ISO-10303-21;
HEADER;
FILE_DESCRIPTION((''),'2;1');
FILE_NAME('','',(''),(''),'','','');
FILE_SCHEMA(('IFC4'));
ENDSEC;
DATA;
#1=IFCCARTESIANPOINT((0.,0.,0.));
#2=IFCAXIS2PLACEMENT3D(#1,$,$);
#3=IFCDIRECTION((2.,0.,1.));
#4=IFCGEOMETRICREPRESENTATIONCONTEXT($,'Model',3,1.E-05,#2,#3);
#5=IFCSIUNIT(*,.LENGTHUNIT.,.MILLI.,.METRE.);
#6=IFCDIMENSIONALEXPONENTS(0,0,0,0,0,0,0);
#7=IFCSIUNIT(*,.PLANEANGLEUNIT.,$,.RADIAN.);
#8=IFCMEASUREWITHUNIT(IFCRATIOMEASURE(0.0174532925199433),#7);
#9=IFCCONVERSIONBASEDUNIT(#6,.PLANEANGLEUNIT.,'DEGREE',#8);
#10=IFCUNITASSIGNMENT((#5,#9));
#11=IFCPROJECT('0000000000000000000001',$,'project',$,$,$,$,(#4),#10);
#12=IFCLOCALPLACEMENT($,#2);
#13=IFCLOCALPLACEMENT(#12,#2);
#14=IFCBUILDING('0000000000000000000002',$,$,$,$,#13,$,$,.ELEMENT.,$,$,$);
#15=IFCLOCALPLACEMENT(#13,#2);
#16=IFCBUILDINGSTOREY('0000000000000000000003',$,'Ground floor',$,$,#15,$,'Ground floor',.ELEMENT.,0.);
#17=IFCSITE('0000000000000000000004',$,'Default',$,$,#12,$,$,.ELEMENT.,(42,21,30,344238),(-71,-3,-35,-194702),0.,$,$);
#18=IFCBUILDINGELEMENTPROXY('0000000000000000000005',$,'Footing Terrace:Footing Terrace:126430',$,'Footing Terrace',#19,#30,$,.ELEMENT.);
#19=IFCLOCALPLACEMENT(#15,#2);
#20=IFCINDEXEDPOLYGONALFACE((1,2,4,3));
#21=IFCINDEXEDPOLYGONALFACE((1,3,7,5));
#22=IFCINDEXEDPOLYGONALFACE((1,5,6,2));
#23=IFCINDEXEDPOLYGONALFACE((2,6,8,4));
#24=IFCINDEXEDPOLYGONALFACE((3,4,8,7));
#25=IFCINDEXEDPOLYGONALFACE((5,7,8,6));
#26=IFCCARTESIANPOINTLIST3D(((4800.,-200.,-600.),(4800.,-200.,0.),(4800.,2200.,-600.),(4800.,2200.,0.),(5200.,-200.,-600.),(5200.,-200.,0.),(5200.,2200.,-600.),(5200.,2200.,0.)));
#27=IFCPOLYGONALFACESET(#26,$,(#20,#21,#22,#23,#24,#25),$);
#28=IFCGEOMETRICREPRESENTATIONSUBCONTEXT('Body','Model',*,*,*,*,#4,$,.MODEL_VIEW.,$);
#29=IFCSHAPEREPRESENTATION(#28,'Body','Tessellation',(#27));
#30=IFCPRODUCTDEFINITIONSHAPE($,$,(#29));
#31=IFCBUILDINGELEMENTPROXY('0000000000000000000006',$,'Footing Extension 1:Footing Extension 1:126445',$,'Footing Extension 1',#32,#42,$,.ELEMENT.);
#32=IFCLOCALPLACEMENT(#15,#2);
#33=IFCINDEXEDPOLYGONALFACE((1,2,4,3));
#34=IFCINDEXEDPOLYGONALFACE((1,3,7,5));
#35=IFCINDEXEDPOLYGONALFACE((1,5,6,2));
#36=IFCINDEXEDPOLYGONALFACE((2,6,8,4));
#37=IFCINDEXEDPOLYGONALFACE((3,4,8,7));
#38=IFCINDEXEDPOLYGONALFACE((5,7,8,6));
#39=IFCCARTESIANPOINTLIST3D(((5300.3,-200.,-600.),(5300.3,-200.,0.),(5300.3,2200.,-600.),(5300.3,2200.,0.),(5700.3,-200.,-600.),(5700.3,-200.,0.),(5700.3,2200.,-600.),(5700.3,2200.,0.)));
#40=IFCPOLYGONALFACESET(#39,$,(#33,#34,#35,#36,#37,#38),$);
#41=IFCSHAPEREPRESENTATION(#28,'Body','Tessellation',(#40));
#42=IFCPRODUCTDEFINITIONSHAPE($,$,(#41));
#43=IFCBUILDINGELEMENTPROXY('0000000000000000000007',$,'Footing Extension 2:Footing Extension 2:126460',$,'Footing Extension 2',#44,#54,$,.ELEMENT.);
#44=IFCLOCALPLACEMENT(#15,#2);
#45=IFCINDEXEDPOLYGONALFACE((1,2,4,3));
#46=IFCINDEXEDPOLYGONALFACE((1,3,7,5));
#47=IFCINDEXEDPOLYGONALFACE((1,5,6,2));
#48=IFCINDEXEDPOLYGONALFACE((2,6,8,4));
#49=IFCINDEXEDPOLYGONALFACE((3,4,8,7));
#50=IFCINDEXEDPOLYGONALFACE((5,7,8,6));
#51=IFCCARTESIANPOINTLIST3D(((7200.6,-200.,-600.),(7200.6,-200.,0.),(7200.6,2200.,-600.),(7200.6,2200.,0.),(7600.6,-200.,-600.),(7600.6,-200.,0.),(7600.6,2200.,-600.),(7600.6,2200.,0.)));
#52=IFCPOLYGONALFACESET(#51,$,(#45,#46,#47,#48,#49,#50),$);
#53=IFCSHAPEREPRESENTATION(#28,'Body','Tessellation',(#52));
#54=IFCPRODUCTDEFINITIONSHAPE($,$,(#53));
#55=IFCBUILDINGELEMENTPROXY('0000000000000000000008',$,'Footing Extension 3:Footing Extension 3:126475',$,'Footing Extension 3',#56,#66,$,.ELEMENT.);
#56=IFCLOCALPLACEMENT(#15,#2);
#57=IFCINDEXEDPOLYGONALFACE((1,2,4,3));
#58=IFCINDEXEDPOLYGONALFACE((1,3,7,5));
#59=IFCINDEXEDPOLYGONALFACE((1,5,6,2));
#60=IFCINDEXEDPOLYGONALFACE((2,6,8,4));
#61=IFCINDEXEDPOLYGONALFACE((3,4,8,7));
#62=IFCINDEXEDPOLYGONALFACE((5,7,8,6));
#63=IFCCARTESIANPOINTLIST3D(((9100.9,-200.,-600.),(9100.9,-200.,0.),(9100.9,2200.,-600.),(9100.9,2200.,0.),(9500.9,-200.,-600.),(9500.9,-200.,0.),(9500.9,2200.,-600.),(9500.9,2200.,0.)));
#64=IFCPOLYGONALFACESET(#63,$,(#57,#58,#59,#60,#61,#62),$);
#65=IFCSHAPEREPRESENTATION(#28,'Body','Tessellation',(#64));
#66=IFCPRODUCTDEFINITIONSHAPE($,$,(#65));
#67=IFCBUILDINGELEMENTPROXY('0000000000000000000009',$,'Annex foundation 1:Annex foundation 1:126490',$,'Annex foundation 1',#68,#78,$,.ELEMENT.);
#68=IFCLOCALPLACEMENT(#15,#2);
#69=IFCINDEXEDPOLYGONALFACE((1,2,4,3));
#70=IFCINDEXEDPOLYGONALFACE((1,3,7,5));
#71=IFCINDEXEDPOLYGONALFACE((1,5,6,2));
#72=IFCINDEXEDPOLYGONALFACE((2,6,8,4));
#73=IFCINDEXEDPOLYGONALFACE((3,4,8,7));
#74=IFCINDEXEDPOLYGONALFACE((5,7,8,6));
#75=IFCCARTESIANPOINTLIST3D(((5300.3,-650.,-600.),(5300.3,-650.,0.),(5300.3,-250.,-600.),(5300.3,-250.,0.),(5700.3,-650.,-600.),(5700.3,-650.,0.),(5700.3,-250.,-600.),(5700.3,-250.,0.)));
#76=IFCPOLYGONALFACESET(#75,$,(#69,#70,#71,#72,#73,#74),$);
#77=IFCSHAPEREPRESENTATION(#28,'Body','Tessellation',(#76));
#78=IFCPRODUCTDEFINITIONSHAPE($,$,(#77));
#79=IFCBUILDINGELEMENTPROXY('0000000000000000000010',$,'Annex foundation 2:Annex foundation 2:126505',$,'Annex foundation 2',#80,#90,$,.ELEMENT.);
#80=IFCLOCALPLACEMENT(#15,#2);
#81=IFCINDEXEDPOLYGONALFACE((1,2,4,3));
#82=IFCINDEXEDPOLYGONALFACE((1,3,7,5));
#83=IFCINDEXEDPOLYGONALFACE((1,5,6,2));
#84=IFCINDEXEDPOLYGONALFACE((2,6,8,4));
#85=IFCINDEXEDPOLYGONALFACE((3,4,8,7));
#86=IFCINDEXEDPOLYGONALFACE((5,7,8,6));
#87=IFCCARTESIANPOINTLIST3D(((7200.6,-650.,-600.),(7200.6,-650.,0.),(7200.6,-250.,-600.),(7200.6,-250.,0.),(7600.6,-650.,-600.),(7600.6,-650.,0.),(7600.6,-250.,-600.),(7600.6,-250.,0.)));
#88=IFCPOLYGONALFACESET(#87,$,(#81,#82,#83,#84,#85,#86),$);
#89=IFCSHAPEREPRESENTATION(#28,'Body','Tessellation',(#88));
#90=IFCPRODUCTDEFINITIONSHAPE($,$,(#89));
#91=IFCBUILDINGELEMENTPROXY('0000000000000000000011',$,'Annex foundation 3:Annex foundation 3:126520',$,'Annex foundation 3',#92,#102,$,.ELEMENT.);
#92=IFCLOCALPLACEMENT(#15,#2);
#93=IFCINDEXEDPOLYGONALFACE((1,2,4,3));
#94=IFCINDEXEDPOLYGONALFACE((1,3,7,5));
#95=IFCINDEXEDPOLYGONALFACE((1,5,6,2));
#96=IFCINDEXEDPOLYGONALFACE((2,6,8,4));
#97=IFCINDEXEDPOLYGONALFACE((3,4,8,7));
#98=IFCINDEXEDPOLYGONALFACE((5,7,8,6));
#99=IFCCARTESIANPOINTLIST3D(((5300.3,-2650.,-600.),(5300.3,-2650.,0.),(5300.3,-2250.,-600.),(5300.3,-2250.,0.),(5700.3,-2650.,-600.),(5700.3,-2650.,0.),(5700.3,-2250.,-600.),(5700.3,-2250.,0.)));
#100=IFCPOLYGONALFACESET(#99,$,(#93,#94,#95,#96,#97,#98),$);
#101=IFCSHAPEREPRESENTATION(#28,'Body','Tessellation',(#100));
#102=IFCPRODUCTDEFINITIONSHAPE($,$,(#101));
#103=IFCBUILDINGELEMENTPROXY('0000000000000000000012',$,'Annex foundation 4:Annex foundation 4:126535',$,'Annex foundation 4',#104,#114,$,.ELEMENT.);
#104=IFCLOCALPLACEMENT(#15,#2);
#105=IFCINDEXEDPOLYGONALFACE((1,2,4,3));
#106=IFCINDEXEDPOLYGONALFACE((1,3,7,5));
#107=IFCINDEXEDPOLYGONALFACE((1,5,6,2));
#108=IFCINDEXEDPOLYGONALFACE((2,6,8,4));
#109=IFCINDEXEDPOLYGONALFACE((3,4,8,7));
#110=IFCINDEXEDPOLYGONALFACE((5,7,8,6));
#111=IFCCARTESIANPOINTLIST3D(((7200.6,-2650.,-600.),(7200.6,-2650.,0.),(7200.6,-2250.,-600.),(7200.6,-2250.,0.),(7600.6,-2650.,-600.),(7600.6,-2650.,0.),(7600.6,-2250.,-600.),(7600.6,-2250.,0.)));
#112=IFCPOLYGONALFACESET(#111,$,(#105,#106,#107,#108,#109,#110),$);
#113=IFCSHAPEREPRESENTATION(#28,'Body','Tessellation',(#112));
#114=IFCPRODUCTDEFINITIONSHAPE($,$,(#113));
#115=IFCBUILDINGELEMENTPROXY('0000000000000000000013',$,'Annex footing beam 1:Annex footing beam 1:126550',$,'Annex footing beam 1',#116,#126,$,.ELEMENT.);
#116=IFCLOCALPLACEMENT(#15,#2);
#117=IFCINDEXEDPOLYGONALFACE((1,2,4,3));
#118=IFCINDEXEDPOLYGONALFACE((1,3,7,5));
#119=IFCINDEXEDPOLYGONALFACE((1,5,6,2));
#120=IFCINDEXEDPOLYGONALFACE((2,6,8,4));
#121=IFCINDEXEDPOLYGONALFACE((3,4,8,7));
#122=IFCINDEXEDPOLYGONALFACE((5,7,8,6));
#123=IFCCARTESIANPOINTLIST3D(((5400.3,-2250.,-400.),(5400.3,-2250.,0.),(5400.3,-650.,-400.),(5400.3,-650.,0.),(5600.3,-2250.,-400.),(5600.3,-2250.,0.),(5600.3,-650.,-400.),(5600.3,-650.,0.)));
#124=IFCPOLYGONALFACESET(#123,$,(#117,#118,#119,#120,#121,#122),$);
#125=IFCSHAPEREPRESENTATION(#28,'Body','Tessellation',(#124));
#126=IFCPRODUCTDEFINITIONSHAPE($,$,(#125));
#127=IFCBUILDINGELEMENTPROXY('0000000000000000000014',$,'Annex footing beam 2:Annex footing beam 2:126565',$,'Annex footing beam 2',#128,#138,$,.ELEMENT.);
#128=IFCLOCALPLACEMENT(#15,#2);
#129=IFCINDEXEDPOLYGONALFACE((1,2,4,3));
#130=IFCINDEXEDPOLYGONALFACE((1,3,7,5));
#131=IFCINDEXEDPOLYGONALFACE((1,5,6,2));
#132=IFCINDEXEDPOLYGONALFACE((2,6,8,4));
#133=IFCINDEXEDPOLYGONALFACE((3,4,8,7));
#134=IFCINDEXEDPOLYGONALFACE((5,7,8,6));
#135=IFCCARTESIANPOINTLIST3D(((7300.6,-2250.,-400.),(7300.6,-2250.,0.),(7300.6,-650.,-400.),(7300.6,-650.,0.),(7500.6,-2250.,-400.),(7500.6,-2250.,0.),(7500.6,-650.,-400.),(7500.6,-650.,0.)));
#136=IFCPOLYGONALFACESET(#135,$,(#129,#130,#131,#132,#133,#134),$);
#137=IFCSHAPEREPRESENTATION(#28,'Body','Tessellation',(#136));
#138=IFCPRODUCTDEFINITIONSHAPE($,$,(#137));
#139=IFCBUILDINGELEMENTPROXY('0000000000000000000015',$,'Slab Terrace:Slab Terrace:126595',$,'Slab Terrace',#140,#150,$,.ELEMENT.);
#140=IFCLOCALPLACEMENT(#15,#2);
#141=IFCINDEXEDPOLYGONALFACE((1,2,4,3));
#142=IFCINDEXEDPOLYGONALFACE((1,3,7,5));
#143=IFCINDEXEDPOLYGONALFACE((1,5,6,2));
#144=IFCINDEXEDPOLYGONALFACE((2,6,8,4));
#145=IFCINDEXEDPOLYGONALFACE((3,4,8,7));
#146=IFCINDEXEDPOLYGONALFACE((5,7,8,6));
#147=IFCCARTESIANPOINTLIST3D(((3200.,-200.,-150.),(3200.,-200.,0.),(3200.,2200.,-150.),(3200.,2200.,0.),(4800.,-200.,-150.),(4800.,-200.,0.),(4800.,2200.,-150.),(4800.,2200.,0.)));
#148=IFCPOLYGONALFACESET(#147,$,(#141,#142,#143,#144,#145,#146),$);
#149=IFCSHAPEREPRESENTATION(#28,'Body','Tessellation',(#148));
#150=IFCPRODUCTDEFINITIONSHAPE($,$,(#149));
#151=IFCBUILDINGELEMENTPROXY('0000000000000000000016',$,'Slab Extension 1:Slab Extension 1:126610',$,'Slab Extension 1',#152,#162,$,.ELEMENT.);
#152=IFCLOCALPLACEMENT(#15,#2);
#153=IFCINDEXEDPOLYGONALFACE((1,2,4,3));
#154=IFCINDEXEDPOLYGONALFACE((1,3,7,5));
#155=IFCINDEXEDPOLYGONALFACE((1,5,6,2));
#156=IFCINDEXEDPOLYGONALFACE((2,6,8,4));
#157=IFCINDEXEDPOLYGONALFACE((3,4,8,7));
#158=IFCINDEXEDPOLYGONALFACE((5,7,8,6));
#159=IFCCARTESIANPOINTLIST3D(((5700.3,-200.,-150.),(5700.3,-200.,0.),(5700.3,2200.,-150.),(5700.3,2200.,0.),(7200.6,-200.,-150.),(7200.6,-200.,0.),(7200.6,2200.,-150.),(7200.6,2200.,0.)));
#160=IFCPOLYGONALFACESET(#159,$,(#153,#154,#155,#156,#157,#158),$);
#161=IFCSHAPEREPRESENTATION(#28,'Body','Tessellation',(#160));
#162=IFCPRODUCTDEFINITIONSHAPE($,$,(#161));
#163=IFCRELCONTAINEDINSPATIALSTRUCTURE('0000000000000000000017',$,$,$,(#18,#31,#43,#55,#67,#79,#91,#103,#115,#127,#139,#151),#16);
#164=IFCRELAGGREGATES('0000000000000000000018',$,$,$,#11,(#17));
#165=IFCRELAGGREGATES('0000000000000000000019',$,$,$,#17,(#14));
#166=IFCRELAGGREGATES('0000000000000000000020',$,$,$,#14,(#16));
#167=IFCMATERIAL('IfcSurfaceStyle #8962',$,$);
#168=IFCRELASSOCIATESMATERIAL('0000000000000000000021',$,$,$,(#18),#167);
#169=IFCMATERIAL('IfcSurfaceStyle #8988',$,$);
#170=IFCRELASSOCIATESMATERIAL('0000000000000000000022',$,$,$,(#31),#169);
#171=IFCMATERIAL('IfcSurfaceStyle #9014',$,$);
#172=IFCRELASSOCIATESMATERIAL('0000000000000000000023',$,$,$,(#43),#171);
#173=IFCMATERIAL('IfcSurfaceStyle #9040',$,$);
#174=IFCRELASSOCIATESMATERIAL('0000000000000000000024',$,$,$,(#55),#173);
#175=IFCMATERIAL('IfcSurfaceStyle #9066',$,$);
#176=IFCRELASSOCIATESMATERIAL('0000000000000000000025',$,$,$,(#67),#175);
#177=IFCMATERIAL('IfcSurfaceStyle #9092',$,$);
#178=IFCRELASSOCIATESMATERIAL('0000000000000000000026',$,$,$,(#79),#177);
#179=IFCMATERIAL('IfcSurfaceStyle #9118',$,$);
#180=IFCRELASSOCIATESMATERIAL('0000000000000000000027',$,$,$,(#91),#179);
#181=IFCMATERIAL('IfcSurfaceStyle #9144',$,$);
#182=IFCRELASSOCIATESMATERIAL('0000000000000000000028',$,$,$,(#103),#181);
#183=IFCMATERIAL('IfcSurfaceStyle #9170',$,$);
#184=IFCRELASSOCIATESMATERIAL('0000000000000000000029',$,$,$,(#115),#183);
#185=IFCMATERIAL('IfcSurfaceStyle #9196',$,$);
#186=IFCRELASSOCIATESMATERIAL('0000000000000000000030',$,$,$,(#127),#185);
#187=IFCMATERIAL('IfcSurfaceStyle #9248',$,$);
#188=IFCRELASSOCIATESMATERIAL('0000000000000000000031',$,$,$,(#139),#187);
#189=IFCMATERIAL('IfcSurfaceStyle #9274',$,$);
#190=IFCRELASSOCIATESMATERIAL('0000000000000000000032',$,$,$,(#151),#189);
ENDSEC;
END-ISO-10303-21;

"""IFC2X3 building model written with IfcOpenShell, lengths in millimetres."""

from ifc_helpers import new_model, entity, si_unit, converted_unit, direction, frame, frame_2d, origin, origin_2d_with_axis, place, context, subcontext, project, spatial, rectangle, extrude, source, transform, mapped, material, element, save


model = new_model("IFC2X3")

# Units and contexts
model_context = context("Model", 3, precision=1e-05, world=origin(), true_north=direction((2.0, 0.0, 1.0)))
body_context = subcontext(model_context, "Body", "Model", "MODEL_VIEW")
ifc_project = project(units=[si_unit("LENGTHUNIT", "METRE", prefix="MILLI"), converted_unit("PLANEANGLEUNIT", "DEGREE", entity("IfcRatioMeasure", 0.0174532925199433), si_unit("PLANEANGLEUNIT", "RADIAN"), dimensions=[0, 0, 0, 0, 0, 0, 0])], contexts=[model_context])

# Site, building, storey
site_placement = place(None, origin())
site = spatial("IfcSite", under=ifc_project, at=site_placement, Name="Default", CompositionType="ELEMENT", RefLatitude=(42, 21, 30, 344238), RefLongitude=(-71, -3, -35, -194702), RefElevation=0.0)
building_placement = place(site_placement, origin())
building = spatial("IfcBuilding", under=site, at=building_placement, CompositionType="ELEMENT")
storey_placement = place(building_placement, origin())
storey = spatial("IfcBuildingStorey", under=building, at=storey_placement, Name="Ground floor", LongName="Ground floor", CompositionType="ELEMENT", Elevation=0.0)

# Building element proxies
ifc_material_1 = material(Name="IfcSurfaceStyle #8962")
shared_shape_1 = source(origin(), body_context, "Body", "SweptSolid", [
    extrude(rectangle(XDim=2400.0, YDim=400.0, at=origin_2d_with_axis()), frame((200.0, 1200.0, 0.0), z_axis=(0.0, 0.0, 1.0), x_axis=(0.0, -1.0, 0.0)), (0.0, 0.0, 1.0), 600.0),
])
proxy_1_placement = place(building_placement, frame((4800.0, -200.0, -600.0)))
element("IfcBuildingElementProxy", 1, at=proxy_1_placement, inside=storey, material=ifc_material_1, Name="Footing Terrace:Footing Terrace:126430", ObjectType="Footing Terrace", CompositionType="ELEMENT", context=body_context, shape_type="MappedRepresentation", body=[
    mapped(shared_shape_1, transform((0.0, 0.0, 0.0), scale=1.0)),
])
ifc_material_2 = material(Name="IfcSurfaceStyle #8988")
shared_shape_2 = source(origin(), body_context, "Body", "SweptSolid", [
    extrude(rectangle(XDim=2400.0, YDim=400.0, at=origin_2d_with_axis()), frame((200.0, 1200.0, 0.0), z_axis=(0.0, 0.0, 1.0), x_axis=(0.0, -1.0, 0.0)), (0.0, 0.0, 1.0), 600.0),
])
proxy_2_placement = place(building_placement, frame((5300.3, -200.0, -600.0)))
element("IfcBuildingElementProxy", 2, at=proxy_2_placement, inside=storey, material=ifc_material_2, Name="Footing Extension 1:Footing Extension 1:126445", ObjectType="Footing Extension 1", CompositionType="ELEMENT", context=body_context, shape_type="MappedRepresentation", body=[
    mapped(shared_shape_2, transform((0.0, 0.0, 0.0), scale=1.0)),
])
ifc_material_3 = material(Name="IfcSurfaceStyle #9014")
shared_shape_3 = source(origin(), body_context, "Body", "SweptSolid", [
    extrude(rectangle(XDim=2400.0, YDim=400.0, at=origin_2d_with_axis()), frame((200.0, 1200.0, 0.0), z_axis=(0.0, 0.0, 1.0), x_axis=(0.0, -1.0, 0.0)), (0.0, 0.0, 1.0), 600.0),
])
proxy_3_placement = place(building_placement, frame((7200.6, -200.0, -600.0)))
element("IfcBuildingElementProxy", 3, at=proxy_3_placement, inside=storey, material=ifc_material_3, Name="Footing Extension 2:Footing Extension 2:126460", ObjectType="Footing Extension 2", CompositionType="ELEMENT", context=body_context, shape_type="MappedRepresentation", body=[
    mapped(shared_shape_3, transform((0.0, 0.0, 0.0), scale=1.0)),
])
ifc_material_4 = material(Name="IfcSurfaceStyle #9040")
shared_shape_4 = source(origin(), body_context, "Body", "SweptSolid", [
    extrude(rectangle(XDim=2400.0, YDim=400.0, at=origin_2d_with_axis()), frame((200.0, 1200.0, 0.0), z_axis=(0.0, 0.0, 1.0), x_axis=(0.0, -1.0, 0.0)), (0.0, 0.0, 1.0), 600.0),
])
proxy_4_placement = place(building_placement, frame((9100.9, -200.0, -600.0)))
element("IfcBuildingElementProxy", 4, at=proxy_4_placement, inside=storey, material=ifc_material_4, Name="Footing Extension 3:Footing Extension 3:126475", ObjectType="Footing Extension 3", CompositionType="ELEMENT", context=body_context, shape_type="MappedRepresentation", body=[
    mapped(shared_shape_4, transform((0.0, 0.0, 0.0), scale=1.0)),
])
ifc_material_5 = material(Name="IfcSurfaceStyle #9066")
shared_shape_5 = source(origin(), body_context, "Body", "SweptSolid", [
    extrude(rectangle(XDim=400.0, YDim=400.0, at=origin_2d_with_axis()), frame((200.0, 200.0, 0.0), z_axis=(0.0, 0.0, 1.0), x_axis=(0.0, 1.0, 0.0)), (0.0, 0.0, 1.0), 600.0),
])
proxy_5_placement = place(building_placement, frame((5300.3, -650.0, -600.0)))
element("IfcBuildingElementProxy", 5, at=proxy_5_placement, inside=storey, material=ifc_material_5, Name="Annex foundation 1:Annex foundation 1:126490", ObjectType="Annex foundation 1", CompositionType="ELEMENT", context=body_context, shape_type="MappedRepresentation", body=[
    mapped(shared_shape_5, transform((0.0, 0.0, 0.0), scale=1.0)),
])
ifc_material_6 = material(Name="IfcSurfaceStyle #9092")
shared_shape_6 = source(origin(), body_context, "Body", "SweptSolid", [
    extrude(rectangle(XDim=400.0, YDim=400.0, at=origin_2d_with_axis()), frame((200.0, 200.0, 0.0), z_axis=(0.0, 0.0, 1.0), x_axis=(0.0, 1.0, 0.0)), (0.0, 0.0, 1.0), 600.0),
])
proxy_6_placement = place(building_placement, frame((7200.6, -650.0, -600.0)))
element("IfcBuildingElementProxy", 6, at=proxy_6_placement, inside=storey, material=ifc_material_6, Name="Annex foundation 2:Annex foundation 2:126505", ObjectType="Annex foundation 2", CompositionType="ELEMENT", context=body_context, shape_type="MappedRepresentation", body=[
    mapped(shared_shape_6, transform((0.0, 0.0, 0.0), scale=1.0)),
])
ifc_material_7 = material(Name="IfcSurfaceStyle #9118")
shared_shape_7 = source(origin(), body_context, "Body", "SweptSolid", [
    extrude(rectangle(XDim=400.0, YDim=400.0, at=origin_2d_with_axis()), frame((200.0, 200.0, 0.0), z_axis=(0.0, 0.0, 1.0), x_axis=(0.0, 1.0, 0.0)), (0.0, 0.0, 1.0), 600.0),
])
proxy_7_placement = place(building_placement, frame((5300.3, -2650.0, -600.0)))
element("IfcBuildingElementProxy", 7, at=proxy_7_placement, inside=storey, material=ifc_material_7, Name="Annex foundation 3:Annex foundation 3:126520", ObjectType="Annex foundation 3", CompositionType="ELEMENT", context=body_context, shape_type="MappedRepresentation", body=[
    mapped(shared_shape_7, transform((0.0, 0.0, 0.0), scale=1.0)),
])
ifc_material_8 = material(Name="IfcSurfaceStyle #9144")
shared_shape_8 = source(origin(), body_context, "Body", "SweptSolid", [
    extrude(rectangle(XDim=400.0, YDim=400.0, at=origin_2d_with_axis()), frame((200.0, 200.0, 0.0), z_axis=(0.0, 0.0, 1.0), x_axis=(0.0, 1.0, 0.0)), (0.0, 0.0, 1.0), 600.0),
])
proxy_8_placement = place(building_placement, frame((7200.6, -2650.0, -600.0)))
element("IfcBuildingElementProxy", 8, at=proxy_8_placement, inside=storey, material=ifc_material_8, Name="Annex foundation 4:Annex foundation 4:126535", ObjectType="Annex foundation 4", CompositionType="ELEMENT", context=body_context, shape_type="MappedRepresentation", body=[
    mapped(shared_shape_8, transform((0.0, 0.0, 0.0), scale=1.0)),
])
ifc_material_9 = material(Name="IfcSurfaceStyle #9170")
shared_shape_9 = source(origin(), body_context, "Body", "SweptSolid", [
    extrude(rectangle(XDim=1600.0, YDim=200.0, at=origin_2d_with_axis()), frame((100.0, 800.0, 0.0), z_axis=(0.0, 0.0, 1.0), x_axis=(0.0, -1.0, 0.0)), (0.0, 0.0, 1.0), 400.0),
])
proxy_9_placement = place(building_placement, frame((5400.3, -2250.0, -400.0)))
element("IfcBuildingElementProxy", 9, at=proxy_9_placement, inside=storey, material=ifc_material_9, Name="Annex footing beam 1:Annex footing beam 1:126550", ObjectType="Annex footing beam 1", CompositionType="ELEMENT", context=body_context, shape_type="MappedRepresentation", body=[
    mapped(shared_shape_9, transform((0.0, 0.0, 0.0), scale=1.0)),
])
ifc_material_10 = material(Name="IfcSurfaceStyle #9196")
shared_shape_10 = source(origin(), body_context, "Body", "SweptSolid", [
    extrude(rectangle(XDim=1600.0, YDim=200.0, at=origin_2d_with_axis()), frame((100.0, 800.0, 0.0), z_axis=(0.0, 0.0, 1.0), x_axis=(0.0, -1.0, 0.0)), (0.0, 0.0, 1.0), 400.0),
])
proxy_10_placement = place(building_placement, frame((7300.6, -2250.0, -400.0)))
element("IfcBuildingElementProxy", 10, at=proxy_10_placement, inside=storey, material=ifc_material_10, Name="Annex footing beam 2:Annex footing beam 2:126565", ObjectType="Annex footing beam 2", CompositionType="ELEMENT", context=body_context, shape_type="MappedRepresentation", body=[
    mapped(shared_shape_10, transform((0.0, 0.0, 0.0), scale=1.0)),
])
ifc_material_11 = material(Name="IfcSurfaceStyle #9248")
shared_shape_11 = source(origin(), body_context, "Body", "SweptSolid", [
    extrude(rectangle(XDim=1600.0, YDim=2400.0, at=origin_2d_with_axis()), frame((800.0, 1200.0, 0.0), z_axis=(0.0, 0.0, 1.0), x_axis=(-1.0, 0.0, 0.0)), (0.0, 0.0, 1.0), 150.0),
])
proxy_11_placement = place(building_placement, frame((3200.0, -200.0, -150.0)))
element("IfcBuildingElementProxy", 11, at=proxy_11_placement, inside=storey, material=ifc_material_11, Name="Slab Terrace:Slab Terrace:126595", ObjectType="Slab Terrace", CompositionType="ELEMENT", context=body_context, shape_type="MappedRepresentation", body=[
    mapped(shared_shape_11, transform((0.0, 0.0, 0.0), scale=1.0)),
])
ifc_material_12 = material(Name="IfcSurfaceStyle #9274")
shared_shape_12 = source(origin(), body_context, "Body", "SweptSolid", [
    extrude(rectangle(XDim=1500.3, YDim=2400.0, at=frame_2d((0.0, 0.0), x_axis=(1.0, 0.0))), frame((750.2, 1200.0, 0.0)), (0.0, 0.0, 1.0), 150.0),
])
proxy_12_placement = place(building_placement, frame((5700.3, -200.0, -150.0)))
element("IfcBuildingElementProxy", 12, at=proxy_12_placement, inside=storey, material=ifc_material_12, Name="Slab Extension 1:Slab Extension 1:126610", ObjectType="Slab Extension 1", CompositionType="ELEMENT", context=body_context, shape_type="MappedRepresentation", body=[
    mapped(shared_shape_12, transform((0.0, 0.0, 0.0), scale=1.0)),
])

save(model, "model.ifc")
